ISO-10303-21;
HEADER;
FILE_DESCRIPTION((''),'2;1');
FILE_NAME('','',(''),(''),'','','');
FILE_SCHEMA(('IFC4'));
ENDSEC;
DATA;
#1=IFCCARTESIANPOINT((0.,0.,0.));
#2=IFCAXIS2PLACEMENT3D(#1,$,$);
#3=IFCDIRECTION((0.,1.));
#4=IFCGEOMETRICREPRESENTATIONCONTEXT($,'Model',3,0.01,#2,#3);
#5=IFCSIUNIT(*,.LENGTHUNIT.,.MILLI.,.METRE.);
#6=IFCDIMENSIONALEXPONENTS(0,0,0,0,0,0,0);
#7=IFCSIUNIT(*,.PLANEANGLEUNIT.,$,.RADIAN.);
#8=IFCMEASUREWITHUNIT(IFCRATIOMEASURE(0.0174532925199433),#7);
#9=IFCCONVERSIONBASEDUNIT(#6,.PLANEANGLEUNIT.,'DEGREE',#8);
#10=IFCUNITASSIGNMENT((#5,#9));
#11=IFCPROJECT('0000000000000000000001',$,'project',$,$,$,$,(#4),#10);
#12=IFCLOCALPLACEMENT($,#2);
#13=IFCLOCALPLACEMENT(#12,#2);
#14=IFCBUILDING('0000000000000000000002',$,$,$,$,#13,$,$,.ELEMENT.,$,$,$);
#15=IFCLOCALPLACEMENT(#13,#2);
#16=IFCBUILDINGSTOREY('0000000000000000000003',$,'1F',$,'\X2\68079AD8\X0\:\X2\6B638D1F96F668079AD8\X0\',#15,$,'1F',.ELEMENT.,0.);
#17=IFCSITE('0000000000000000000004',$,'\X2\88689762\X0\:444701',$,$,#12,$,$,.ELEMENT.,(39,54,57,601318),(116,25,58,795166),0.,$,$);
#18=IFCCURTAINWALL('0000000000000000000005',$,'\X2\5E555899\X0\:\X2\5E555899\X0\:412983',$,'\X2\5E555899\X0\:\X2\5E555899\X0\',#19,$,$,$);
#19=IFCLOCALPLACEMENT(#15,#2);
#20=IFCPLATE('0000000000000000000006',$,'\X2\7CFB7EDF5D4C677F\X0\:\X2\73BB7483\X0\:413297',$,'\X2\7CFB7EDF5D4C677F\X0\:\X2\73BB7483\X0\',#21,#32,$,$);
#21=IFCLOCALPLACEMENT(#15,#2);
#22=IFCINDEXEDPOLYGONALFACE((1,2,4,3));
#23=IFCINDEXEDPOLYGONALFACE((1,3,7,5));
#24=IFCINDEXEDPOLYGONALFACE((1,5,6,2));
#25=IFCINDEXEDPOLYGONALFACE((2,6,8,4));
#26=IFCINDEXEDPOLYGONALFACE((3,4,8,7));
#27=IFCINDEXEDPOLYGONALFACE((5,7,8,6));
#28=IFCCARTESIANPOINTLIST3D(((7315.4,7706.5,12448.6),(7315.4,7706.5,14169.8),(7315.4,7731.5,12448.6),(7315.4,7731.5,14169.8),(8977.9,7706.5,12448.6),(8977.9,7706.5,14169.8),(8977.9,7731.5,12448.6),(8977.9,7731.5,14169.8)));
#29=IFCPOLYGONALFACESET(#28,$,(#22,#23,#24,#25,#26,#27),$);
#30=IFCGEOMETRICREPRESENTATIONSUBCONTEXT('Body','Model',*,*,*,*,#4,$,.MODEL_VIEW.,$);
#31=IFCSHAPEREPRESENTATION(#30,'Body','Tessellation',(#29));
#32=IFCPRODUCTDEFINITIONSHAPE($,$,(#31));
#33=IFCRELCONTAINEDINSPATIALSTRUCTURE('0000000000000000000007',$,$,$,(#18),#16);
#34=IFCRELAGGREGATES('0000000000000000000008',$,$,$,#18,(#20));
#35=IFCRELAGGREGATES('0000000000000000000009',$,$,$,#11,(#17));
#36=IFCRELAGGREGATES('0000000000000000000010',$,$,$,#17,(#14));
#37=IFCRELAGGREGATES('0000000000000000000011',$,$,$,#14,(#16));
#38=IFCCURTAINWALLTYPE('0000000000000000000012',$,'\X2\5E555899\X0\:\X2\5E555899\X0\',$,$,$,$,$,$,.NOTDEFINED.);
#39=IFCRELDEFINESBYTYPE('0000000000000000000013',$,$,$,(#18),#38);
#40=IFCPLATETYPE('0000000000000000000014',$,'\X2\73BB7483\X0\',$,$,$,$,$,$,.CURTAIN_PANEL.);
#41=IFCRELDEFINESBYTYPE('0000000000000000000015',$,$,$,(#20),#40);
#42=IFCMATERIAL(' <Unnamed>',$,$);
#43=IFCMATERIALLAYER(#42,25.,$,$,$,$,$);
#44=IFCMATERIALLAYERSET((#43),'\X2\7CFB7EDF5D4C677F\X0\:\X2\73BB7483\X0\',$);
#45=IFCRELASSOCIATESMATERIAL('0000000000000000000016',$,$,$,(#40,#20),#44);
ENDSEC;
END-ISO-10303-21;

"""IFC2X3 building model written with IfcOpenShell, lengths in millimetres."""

from ifc_helpers import new_model, entity, si_unit, converted_unit, direction, frame, origin, origin_2d_with_axis, place, context, subcontext, project, spatial, rectangle, extrude, source, transform, mapped, material, layer, layer_set, layer_usage, type_object, type_shapes, element, aggregate, save


model = new_model("IFC2X3")

# Units and contexts
model_context = context("Model", 3, precision=0.01, world=origin(), true_north=direction((0.0, 1.0)))
body_context = subcontext(model_context, "Body", "Model", "MODEL_VIEW")
ifc_project = project(units=[si_unit("LENGTHUNIT", "METRE", prefix="MILLI"), converted_unit("PLANEANGLEUNIT", "DEGREE", entity("IfcRatioMeasure", 0.0174532925199433), si_unit("PLANEANGLEUNIT", "RADIAN"), dimensions=[0, 0, 0, 0, 0, 0, 0])], contexts=[model_context])

# Site, building, storey
site_placement = place(None, origin())
site = spatial("IfcSite", under=ifc_project, at=site_placement, Name="表面:444701", CompositionType="ELEMENT", RefLatitude=(39, 54, 57, 601318), RefLongitude=(116, 25, 58, 795166), RefElevation=0.0)
building_placement = place(site_placement, origin())
building = spatial("IfcBuilding", under=site, at=building_placement, CompositionType="ELEMENT")
storey_placement = place(building_placement, origin())
storey = spatial("IfcBuildingStorey", under=building, at=storey_placement, Name="1F", ObjectType="标高:正负零标高", LongName="1F", CompositionType="ELEMENT", Elevation=0.0)

# Shared definitions
curtain_wall_type = type_object("IfcCurtainWallType", Name="幕墙:幕墙", PredefinedType="NOTDEFINED")

# Curtain wall, plate
curtain_wall_1_placement = place(storey_placement, origin())
curtain_wall_1 = element("IfcCurtainWall", 1, at=curtain_wall_1_placement, inside=storey, type_object=curtain_wall_type, Name="幕墙:幕墙:412983", ObjectType="幕墙:幕墙")
ifc_material_1 = material(Name=" <Unnamed>")
ifc_layer = layer(ifc_material_1, 25.0)
ifc_layer_set = layer_set([ifc_layer], Name="系统嵌板:玻璃")
plate_type = type_object("IfcPlateType", Name="玻璃", PredefinedType="CURTAIN_PANEL", material=ifc_layer_set)
shared_shape_1 = source(origin(), body_context, "Body", "SweptSolid", [
    extrude(rectangle(XDim=25.0, YDim=1662.5, at=origin_2d_with_axis()), frame((0.0, 0.0, 0.0), z_axis=(0.0, 0.0, 1.0), x_axis=(0.0, 1.0, 0.0)), (0.0, 0.0, 1.0), 1721.2),
])
type_shapes(plate_type, [shared_shape_1])
ifc_layer_usage_1 = layer_usage(ifc_layer_set, "AXIS3", "POSITIVE", 0.0)
plate_1_placement = place(curtain_wall_1_placement, frame((8146.7, 7719.0, 12448.6)))
plate_1 = element("IfcPlate", 2, at=plate_1_placement, type_object=plate_type, material=ifc_layer_usage_1, Name="系统嵌板:玻璃:413297", ObjectType="系统嵌板:玻璃", context=body_context, shape_type="MappedRepresentation", body=[
    mapped(shared_shape_1, transform((0.0, 0.0, 0.0), scale=1.0)),
])
aggregate(curtain_wall_1, [plate_1])

save(model, "model.ifc")
